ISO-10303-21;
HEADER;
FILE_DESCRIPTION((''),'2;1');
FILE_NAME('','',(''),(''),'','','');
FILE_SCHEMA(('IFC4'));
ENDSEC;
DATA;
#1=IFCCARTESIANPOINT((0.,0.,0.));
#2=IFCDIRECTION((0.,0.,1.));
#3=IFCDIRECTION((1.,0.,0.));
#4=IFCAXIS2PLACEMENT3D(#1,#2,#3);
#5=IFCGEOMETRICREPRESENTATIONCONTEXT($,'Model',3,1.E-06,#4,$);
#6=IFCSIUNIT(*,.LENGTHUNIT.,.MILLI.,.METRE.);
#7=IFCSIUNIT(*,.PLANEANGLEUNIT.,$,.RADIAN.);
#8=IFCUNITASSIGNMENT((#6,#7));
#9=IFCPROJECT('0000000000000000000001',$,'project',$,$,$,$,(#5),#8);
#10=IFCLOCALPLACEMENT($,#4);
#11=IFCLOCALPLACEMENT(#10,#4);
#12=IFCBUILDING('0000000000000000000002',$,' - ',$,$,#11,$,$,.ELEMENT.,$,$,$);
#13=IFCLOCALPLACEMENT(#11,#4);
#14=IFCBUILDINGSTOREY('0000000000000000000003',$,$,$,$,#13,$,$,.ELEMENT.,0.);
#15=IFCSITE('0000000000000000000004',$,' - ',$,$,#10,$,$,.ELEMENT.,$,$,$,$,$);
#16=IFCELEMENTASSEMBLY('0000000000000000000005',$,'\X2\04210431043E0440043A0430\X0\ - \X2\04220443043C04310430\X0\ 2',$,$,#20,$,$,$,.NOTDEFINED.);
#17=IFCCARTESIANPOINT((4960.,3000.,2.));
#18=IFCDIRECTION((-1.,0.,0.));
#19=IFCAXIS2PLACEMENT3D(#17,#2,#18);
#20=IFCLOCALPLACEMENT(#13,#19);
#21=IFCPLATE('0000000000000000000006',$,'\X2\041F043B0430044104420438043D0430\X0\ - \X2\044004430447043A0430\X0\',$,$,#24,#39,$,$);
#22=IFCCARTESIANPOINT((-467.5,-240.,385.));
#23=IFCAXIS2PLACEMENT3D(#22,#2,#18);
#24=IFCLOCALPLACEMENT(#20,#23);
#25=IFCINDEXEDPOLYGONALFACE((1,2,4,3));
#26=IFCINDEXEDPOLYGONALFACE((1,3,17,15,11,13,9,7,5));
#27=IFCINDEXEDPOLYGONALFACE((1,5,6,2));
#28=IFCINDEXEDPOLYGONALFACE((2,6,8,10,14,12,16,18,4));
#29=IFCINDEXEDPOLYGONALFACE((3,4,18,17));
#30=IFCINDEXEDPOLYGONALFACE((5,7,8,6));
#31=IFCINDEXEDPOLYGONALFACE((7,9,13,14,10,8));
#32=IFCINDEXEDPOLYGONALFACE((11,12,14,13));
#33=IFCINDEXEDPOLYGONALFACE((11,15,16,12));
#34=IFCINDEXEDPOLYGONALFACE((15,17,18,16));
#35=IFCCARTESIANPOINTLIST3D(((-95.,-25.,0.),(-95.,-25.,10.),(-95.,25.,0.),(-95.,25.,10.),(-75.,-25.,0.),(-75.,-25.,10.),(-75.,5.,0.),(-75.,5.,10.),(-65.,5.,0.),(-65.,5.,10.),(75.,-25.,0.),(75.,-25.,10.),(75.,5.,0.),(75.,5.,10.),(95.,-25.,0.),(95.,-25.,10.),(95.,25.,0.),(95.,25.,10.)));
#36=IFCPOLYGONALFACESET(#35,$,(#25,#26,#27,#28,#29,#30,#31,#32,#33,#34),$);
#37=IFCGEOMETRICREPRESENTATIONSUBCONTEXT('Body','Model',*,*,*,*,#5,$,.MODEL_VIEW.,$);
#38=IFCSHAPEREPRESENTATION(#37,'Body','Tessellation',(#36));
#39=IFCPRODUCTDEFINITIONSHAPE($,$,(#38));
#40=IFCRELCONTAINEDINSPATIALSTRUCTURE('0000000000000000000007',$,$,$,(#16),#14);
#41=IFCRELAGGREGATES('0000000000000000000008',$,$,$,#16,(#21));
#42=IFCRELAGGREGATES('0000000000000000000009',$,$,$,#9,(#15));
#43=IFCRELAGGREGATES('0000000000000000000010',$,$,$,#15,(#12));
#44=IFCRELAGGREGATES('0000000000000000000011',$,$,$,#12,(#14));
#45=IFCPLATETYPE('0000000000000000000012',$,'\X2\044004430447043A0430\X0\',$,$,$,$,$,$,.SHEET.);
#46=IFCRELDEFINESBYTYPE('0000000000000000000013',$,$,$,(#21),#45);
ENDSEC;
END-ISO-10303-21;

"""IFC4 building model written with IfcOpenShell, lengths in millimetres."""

from ifc_helpers import new_model, si_unit, frame, origin_with_axes, place, context, subcontext, project, spatial, line, indexed_curve, outline, extrude, source, transform, mapped, type_object, element, aggregate, save


model = new_model("IFC4")

# Units and contexts
model_context = context("Model", 3, precision=1e-06, world=origin_with_axes())
body_context = subcontext(model_context, "Body", "Model", "MODEL_VIEW")
ifc_project = project(units=[si_unit("LENGTHUNIT", "METRE", prefix="MILLI"), si_unit("PLANEANGLEUNIT", "RADIAN")], contexts=[model_context])

# Site, building, storey
site_placement = place(None, origin_with_axes())
site = spatial("IfcSite", under=ifc_project, at=site_placement, Name=" - ", CompositionType="ELEMENT")
building_placement = place(site_placement, origin_with_axes())
building = spatial("IfcBuilding", under=site, at=building_placement, Name=" - ", CompositionType="ELEMENT")
storey_placement = place(building_placement, origin_with_axes())
storey = spatial("IfcBuildingStorey", under=building, at=storey_placement, CompositionType="ELEMENT", Elevation=0.0)

# Element assembly, plate
assembly_1_placement = place(storey_placement, frame((4960.0, 3000.0, 2.0), z_axis=(0.0, 0.0, 1.0), x_axis=(-1.0, 0.0, 0.0)))
assembly_1 = element("IfcElementAssembly", 1, at=assembly_1_placement, inside=storey, Name="Сборка - Тумба 2", PredefinedType="NOTDEFINED")
plate_type = type_object("IfcPlateType", Name="ручка", PredefinedType="SHEET")
shared_shape_1 = source(origin_with_axes(), body_context, "Body", "SweptSolid", [
    extrude(outline(indexed_curve([(-95.0, -25.0), (-75.0, -25.0), (-75.0, 5.0), (-65.0, 5.0), (75.0, 5.0), (75.0, -25.0), (95.0, -25.0), (95.0, 25.0), (-95.0, 25.0)], segments=[line(1, 2), line(2, 3), line(3, 4), line(4, 5), line(5, 6), line(6, 7), line(7, 8), line(8, 9), line(9, 1)])), origin_with_axes(), (0.0, 0.0, 1.0), 10.0),
])
plate_1_placement = place(assembly_1_placement, frame((-467.5, -240.0, 385.0), z_axis=(0.0, 0.0, 1.0), x_axis=(-1.0, 0.0, 0.0)))
plate_1 = element("IfcPlate", 2, at=plate_1_placement, type_object=plate_type, Name="Пластина - ручка", context=body_context, shape_type="MappedRepresentation", body=[
    mapped(shared_shape_1, transform((0.0, 0.0, 0.0), x_axis=(1.0, 0.0, 0.0), y_axis=(0.0, 1.0, 0.0), z_axis=(0.0, 0.0, 1.0), scale=1.0)),
])
aggregate(assembly_1, [plate_1])

save(model, "model.ifc")
